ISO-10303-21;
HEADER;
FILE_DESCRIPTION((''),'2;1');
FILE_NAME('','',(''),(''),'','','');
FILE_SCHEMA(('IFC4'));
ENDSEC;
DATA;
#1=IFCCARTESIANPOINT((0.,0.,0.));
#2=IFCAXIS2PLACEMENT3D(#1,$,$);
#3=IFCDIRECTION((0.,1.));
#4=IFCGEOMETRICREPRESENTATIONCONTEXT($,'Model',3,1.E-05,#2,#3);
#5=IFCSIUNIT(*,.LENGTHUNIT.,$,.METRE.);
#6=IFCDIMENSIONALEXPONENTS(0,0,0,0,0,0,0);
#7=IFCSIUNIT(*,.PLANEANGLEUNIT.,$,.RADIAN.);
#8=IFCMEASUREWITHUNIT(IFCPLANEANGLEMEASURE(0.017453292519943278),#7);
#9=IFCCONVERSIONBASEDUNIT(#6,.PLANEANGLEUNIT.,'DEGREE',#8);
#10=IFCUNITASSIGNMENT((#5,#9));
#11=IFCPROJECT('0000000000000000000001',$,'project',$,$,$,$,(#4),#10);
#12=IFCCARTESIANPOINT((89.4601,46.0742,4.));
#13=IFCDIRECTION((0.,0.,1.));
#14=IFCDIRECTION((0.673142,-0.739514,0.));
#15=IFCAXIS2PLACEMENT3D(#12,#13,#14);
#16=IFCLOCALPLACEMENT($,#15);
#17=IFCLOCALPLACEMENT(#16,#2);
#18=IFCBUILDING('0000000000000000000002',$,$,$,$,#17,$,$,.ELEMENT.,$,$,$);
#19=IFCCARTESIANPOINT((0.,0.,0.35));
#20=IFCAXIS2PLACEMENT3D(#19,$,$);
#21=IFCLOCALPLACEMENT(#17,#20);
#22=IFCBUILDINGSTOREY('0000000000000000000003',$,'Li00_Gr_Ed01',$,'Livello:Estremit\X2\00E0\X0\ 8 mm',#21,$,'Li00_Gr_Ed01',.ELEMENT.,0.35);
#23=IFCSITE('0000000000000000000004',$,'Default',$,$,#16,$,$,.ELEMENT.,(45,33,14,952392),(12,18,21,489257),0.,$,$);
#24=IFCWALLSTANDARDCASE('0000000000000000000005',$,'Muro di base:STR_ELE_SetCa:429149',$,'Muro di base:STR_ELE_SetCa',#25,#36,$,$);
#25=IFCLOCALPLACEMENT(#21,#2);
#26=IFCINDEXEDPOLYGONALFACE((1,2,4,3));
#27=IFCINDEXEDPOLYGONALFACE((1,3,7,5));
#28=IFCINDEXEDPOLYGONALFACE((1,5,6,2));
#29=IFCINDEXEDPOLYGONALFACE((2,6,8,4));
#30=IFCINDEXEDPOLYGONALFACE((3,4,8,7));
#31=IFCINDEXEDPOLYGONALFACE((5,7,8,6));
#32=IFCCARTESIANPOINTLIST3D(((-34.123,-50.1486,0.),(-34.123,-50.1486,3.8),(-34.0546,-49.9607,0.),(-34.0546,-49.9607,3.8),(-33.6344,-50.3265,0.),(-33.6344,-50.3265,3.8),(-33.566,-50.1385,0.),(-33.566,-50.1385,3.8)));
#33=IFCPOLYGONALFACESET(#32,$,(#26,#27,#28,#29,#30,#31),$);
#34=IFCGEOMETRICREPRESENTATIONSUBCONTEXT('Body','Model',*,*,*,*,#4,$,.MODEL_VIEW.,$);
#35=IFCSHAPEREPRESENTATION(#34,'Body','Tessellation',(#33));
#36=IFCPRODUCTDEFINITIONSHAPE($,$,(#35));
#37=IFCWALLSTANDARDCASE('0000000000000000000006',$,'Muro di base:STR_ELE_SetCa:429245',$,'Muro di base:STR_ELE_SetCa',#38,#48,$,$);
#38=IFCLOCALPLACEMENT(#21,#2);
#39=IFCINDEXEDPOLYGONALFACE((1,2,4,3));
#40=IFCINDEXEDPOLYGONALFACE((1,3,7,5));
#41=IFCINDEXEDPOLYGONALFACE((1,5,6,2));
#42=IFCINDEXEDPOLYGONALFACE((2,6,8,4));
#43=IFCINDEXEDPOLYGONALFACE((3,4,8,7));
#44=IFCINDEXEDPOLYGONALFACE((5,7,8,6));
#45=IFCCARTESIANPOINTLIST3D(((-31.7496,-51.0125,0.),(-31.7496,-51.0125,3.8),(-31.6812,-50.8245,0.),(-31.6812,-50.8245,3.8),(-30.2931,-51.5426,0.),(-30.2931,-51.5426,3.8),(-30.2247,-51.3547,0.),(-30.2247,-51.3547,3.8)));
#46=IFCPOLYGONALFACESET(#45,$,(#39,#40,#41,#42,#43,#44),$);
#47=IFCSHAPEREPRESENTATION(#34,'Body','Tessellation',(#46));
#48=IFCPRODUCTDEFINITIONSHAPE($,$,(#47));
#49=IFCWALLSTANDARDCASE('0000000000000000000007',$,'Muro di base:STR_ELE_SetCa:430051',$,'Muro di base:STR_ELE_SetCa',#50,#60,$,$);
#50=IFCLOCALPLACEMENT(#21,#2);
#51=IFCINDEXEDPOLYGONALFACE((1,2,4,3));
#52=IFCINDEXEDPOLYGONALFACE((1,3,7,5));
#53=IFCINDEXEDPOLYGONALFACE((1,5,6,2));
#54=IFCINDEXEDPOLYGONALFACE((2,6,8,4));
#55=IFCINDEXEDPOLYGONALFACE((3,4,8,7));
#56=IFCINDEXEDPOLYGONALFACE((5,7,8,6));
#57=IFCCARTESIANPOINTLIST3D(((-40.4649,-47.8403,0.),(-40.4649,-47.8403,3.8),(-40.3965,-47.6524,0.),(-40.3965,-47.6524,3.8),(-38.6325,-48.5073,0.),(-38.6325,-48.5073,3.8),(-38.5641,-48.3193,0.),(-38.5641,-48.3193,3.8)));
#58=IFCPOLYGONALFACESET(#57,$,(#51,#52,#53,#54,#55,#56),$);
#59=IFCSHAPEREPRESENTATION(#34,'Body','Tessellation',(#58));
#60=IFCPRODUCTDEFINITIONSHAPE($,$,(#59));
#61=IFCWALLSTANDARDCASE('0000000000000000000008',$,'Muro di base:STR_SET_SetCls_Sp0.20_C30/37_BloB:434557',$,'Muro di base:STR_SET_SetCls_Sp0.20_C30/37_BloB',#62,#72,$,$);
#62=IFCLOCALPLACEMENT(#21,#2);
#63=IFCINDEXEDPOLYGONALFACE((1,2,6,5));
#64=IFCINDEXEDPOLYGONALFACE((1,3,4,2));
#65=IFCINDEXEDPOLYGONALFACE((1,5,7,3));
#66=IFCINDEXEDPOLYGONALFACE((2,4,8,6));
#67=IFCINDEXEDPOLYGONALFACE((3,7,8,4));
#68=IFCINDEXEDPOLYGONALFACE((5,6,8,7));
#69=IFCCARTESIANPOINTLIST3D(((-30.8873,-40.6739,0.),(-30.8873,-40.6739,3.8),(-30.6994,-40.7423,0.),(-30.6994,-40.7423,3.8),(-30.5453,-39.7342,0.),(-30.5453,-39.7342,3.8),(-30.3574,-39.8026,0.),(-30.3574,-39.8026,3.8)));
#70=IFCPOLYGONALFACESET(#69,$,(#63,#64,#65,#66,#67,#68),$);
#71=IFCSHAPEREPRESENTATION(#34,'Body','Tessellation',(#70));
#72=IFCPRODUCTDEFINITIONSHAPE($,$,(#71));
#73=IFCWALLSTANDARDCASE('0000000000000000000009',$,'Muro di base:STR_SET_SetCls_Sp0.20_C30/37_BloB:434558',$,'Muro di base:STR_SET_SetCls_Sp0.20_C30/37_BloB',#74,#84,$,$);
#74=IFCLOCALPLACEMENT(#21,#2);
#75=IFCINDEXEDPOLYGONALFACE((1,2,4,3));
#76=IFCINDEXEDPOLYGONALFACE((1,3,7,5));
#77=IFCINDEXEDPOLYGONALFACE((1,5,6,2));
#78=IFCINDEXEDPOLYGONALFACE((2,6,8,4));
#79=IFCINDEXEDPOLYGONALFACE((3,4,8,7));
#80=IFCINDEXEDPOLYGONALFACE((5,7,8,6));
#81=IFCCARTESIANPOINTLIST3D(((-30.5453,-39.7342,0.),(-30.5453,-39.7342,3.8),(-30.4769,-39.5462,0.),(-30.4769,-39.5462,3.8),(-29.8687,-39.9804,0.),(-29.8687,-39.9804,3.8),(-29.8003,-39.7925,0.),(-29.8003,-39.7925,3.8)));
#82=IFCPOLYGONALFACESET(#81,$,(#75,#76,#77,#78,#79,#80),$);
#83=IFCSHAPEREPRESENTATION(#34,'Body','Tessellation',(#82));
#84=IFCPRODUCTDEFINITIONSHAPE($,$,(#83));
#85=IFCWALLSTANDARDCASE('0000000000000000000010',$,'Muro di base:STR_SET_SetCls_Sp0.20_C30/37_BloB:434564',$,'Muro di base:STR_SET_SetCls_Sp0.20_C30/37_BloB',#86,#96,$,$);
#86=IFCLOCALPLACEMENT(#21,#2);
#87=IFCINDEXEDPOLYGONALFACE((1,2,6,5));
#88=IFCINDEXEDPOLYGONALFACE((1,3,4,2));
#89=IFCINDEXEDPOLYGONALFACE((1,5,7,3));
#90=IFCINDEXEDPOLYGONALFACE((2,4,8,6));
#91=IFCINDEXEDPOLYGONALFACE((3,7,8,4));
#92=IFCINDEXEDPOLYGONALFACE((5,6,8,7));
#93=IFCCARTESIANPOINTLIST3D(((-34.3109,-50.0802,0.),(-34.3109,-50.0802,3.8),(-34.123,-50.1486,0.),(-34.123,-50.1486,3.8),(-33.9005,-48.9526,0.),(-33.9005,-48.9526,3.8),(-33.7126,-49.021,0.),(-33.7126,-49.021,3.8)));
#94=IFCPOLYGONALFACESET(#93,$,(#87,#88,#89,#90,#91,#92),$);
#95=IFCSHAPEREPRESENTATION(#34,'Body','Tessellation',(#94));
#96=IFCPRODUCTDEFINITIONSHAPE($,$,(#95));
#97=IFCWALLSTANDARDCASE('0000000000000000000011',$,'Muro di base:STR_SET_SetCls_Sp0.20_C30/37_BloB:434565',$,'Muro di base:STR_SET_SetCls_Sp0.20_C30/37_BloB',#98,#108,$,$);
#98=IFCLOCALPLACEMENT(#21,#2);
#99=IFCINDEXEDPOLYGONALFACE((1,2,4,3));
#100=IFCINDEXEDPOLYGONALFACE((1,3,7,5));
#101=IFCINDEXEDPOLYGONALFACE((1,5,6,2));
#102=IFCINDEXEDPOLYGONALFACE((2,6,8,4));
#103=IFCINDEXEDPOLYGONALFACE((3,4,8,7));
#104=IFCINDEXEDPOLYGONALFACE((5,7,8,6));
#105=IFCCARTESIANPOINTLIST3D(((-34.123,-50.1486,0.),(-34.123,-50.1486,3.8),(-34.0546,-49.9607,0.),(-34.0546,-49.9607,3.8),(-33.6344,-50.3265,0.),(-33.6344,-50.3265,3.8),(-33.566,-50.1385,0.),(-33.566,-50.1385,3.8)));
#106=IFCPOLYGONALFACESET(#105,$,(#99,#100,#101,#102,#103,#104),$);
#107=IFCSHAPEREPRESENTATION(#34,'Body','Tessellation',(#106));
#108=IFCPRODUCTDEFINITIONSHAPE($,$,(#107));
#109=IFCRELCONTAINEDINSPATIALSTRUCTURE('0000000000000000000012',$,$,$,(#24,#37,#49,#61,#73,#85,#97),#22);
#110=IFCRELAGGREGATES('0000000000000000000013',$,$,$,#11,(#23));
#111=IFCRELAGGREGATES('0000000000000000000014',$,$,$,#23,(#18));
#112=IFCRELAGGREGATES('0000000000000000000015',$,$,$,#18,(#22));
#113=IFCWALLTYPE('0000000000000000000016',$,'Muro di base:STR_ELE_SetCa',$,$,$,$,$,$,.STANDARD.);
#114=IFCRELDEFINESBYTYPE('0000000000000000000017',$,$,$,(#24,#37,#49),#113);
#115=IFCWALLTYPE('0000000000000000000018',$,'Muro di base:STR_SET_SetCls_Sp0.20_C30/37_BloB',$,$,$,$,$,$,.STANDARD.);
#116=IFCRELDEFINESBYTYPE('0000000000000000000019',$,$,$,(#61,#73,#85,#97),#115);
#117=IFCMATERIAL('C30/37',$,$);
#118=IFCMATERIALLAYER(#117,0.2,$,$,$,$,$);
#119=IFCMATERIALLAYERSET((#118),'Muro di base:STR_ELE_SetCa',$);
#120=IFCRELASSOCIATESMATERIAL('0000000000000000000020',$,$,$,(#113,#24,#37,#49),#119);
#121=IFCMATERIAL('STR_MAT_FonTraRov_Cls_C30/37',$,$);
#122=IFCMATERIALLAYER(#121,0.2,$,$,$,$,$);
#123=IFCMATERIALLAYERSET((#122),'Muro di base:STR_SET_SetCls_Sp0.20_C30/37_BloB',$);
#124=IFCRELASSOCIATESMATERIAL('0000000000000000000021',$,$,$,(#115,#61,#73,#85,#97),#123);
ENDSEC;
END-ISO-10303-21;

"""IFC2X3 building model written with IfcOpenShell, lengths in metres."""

from ifc_helpers import new_model, entity, si_unit, converted_unit, direction, frame, frame_2d, origin, place, context, subcontext, project, spatial, rectangle, extrude, material, layer, layer_set, layer_usage, type_object, element, save


model = new_model("IFC2X3")

# Units and contexts
model_context = context("Model", 3, precision=1e-05, world=origin(), true_north=direction((0.0, 1.0)))
body_context = subcontext(model_context, "Body", "Model", "MODEL_VIEW")
ifc_project = project(units=[si_unit("LENGTHUNIT", "METRE"), converted_unit("PLANEANGLEUNIT", "DEGREE", entity("IfcPlaneAngleMeasure", 0.017453292519943278), si_unit("PLANEANGLEUNIT", "RADIAN"), dimensions=[0, 0, 0, 0, 0, 0, 0])], contexts=[model_context])

# Site, building, storey
site_placement = place(None, frame((89.4601, 46.0742, 4.0), z_axis=(0.0, 0.0, 1.0), x_axis=(0.673142, -0.739514, 0.0)))
site = spatial("IfcSite", under=ifc_project, at=site_placement, Name="Default", CompositionType="ELEMENT", RefLatitude=(45, 33, 14, 952392), RefLongitude=(12, 18, 21, 489257), RefElevation=0.0)
building_placement = place(site_placement, origin())
building = spatial("IfcBuilding", under=site, at=building_placement, CompositionType="ELEMENT")
storey_placement = place(building_placement, frame((0.0, 0.0, 0.35)))
storey = spatial("IfcBuildingStorey", under=building, at=storey_placement, Name="Li00_Gr_Ed01", ObjectType="Livello:Estremità 8 mm", LongName="Li00_Gr_Ed01", CompositionType="ELEMENT", Elevation=0.35)

# Walls
ifc_material_1 = material(Name="C30/37")
ifc_layer_1 = layer(ifc_material_1, 0.2)
ifc_layer_set_1 = layer_set([ifc_layer_1], Name="Muro di base:STR_ELE_SetCa")
ifc_layer_usage_1 = layer_usage(ifc_layer_set_1, "AXIS2", "NEGATIVE", 0.1)
wall_type_1 = type_object("IfcWallType", Name="Muro di base:STR_ELE_SetCa", PredefinedType="STANDARD", material=ifc_layer_set_1)
wall_1_placement = place(storey_placement, frame((-34.0888, -50.0546, 0.0), z_axis=(0.0, 0.0, 1.0), x_axis=(0.939693, -0.34202, 0.0)))
element("IfcWallStandardCase", 1, at=wall_1_placement, inside=storey, type_object=wall_type_1, material=ifc_layer_usage_1, Name="Muro di base:STR_ELE_SetCa:429149", ObjectType="Muro di base:STR_ELE_SetCa", context=body_context, shape_type="SweptSolid", body=[
    extrude(rectangle(XDim=0.52, YDim=0.2, at=frame_2d((0.26, 0.0), x_axis=(-1.0, 0.0))), origin(), (0.0, 0.0, 1.0), 3.8),
])
wall_2_placement = place(storey_placement, frame((-31.7154, -50.9185, 0.0), z_axis=(0.0, 0.0, 1.0), x_axis=(0.939693, -0.34202, 0.0)))
element("IfcWallStandardCase", 2, at=wall_2_placement, inside=storey, type_object=wall_type_1, material=ifc_layer_usage_1, Name="Muro di base:STR_ELE_SetCa:429245", ObjectType="Muro di base:STR_ELE_SetCa", context=body_context, shape_type="SweptSolid", body=[
    extrude(rectangle(XDim=1.55, YDim=0.2, at=frame_2d((0.775, 0.0), x_axis=(-1.0, 0.0))), origin(), (0.0, 0.0, 1.0), 3.8),
])
wall_3_placement = place(storey_placement, frame((-38.5983, -48.4133, 0.0), z_axis=(0.0, 0.0, 1.0), x_axis=(-0.939693, 0.34202, 0.0)))
element("IfcWallStandardCase", 3, at=wall_3_placement, inside=storey, type_object=wall_type_1, material=ifc_layer_usage_1, Name="Muro di base:STR_ELE_SetCa:430051", ObjectType="Muro di base:STR_ELE_SetCa", context=body_context, shape_type="SweptSolid", body=[
    extrude(rectangle(XDim=1.95, YDim=0.2, at=frame_2d((0.975, 0.0), x_axis=(-1.0, 0.0))), origin(), (0.0, 0.0, 1.0), 3.8),
])
ifc_material_2 = material(Name="STR_MAT_FonTraRov_Cls_C30/37")
ifc_layer_2 = layer(ifc_material_2, 0.2)
ifc_layer_set_2 = layer_set([ifc_layer_2], Name="Muro di base:STR_SET_SetCls_Sp0.20_C30/37_BloB")
ifc_layer_usage_2 = layer_usage(ifc_layer_set_2, "AXIS2", "NEGATIVE", 0.1)
wall_type_2 = type_object("IfcWallType", Name="Muro di base:STR_SET_SetCls_Sp0.20_C30/37_BloB", PredefinedType="STANDARD", material=ifc_layer_set_2)
wall_4_placement = place(storey_placement, frame((-30.7934, -40.7081, 0.0), z_axis=(0.0, 0.0, 1.0), x_axis=(0.34202, 0.939693, 0.0)))
element("IfcWallStandardCase", 4, at=wall_4_placement, inside=storey, type_object=wall_type_2, material=ifc_layer_usage_2, Name="Muro di base:STR_SET_SetCls_Sp0.20_C30/37_BloB:434557", ObjectType="Muro di base:STR_SET_SetCls_Sp0.20_C30/37_BloB", context=body_context, shape_type="SweptSolid", body=[
    extrude(rectangle(XDim=1.0, YDim=0.2, at=frame_2d((0.5, 0.0), x_axis=(-1.0, 0.0))), origin(), (0.0, 0.0, 1.0), 3.8),
])
wall_5_placement = place(storey_placement, frame((-29.8345, -39.8865, 0.0), z_axis=(0.0, 0.0, 1.0), x_axis=(-0.939693, 0.34202, 0.0)))
element("IfcWallStandardCase", 5, at=wall_5_placement, inside=storey, type_object=wall_type_2, material=ifc_layer_usage_2, Name="Muro di base:STR_SET_SetCls_Sp0.20_C30/37_BloB:434558", ObjectType="Muro di base:STR_SET_SetCls_Sp0.20_C30/37_BloB", context=body_context, shape_type="SweptSolid", body=[
    extrude(rectangle(XDim=0.72, YDim=0.2, at=frame_2d((0.36, 0.0), x_axis=(-1.0, 0.0))), origin(), (0.0, 0.0, 1.0), 3.8),
])
wall_6_placement = place(storey_placement, frame((-33.8065, -48.9868, 0.0), z_axis=(0.0, 0.0, 1.0), x_axis=(-0.34202, -0.939693, 0.0)))
element("IfcWallStandardCase", 6, at=wall_6_placement, inside=storey, type_object=wall_type_2, material=ifc_layer_usage_2, Name="Muro di base:STR_SET_SetCls_Sp0.20_C30/37_BloB:434564", ObjectType="Muro di base:STR_SET_SetCls_Sp0.20_C30/37_BloB", context=body_context, shape_type="SweptSolid", body=[
    extrude(rectangle(XDim=1.2, YDim=0.2, at=frame_2d((0.6, 0.0), x_axis=(-1.0, 0.0))), origin(), (0.0, 0.0, 1.0), 3.8),
])
wall_7_placement = place(storey_placement, frame((-33.6002, -50.2325, 0.0), z_axis=(0.0, 0.0, 1.0), x_axis=(-0.939693, 0.34202, 0.0)))
element("IfcWallStandardCase", 7, at=wall_7_placement, inside=storey, type_object=wall_type_2, material=ifc_layer_usage_2, Name="Muro di base:STR_SET_SetCls_Sp0.20_C30/37_BloB:434565", ObjectType="Muro di base:STR_SET_SetCls_Sp0.20_C30/37_BloB", context=body_context, shape_type="SweptSolid", body=[
    extrude(rectangle(XDim=0.52, YDim=0.2, at=frame_2d((0.26, 0.0), x_axis=(-1.0, 0.0))), origin(), (0.0, 0.0, 1.0), 3.8),
])

save(model, "model.ifc")
